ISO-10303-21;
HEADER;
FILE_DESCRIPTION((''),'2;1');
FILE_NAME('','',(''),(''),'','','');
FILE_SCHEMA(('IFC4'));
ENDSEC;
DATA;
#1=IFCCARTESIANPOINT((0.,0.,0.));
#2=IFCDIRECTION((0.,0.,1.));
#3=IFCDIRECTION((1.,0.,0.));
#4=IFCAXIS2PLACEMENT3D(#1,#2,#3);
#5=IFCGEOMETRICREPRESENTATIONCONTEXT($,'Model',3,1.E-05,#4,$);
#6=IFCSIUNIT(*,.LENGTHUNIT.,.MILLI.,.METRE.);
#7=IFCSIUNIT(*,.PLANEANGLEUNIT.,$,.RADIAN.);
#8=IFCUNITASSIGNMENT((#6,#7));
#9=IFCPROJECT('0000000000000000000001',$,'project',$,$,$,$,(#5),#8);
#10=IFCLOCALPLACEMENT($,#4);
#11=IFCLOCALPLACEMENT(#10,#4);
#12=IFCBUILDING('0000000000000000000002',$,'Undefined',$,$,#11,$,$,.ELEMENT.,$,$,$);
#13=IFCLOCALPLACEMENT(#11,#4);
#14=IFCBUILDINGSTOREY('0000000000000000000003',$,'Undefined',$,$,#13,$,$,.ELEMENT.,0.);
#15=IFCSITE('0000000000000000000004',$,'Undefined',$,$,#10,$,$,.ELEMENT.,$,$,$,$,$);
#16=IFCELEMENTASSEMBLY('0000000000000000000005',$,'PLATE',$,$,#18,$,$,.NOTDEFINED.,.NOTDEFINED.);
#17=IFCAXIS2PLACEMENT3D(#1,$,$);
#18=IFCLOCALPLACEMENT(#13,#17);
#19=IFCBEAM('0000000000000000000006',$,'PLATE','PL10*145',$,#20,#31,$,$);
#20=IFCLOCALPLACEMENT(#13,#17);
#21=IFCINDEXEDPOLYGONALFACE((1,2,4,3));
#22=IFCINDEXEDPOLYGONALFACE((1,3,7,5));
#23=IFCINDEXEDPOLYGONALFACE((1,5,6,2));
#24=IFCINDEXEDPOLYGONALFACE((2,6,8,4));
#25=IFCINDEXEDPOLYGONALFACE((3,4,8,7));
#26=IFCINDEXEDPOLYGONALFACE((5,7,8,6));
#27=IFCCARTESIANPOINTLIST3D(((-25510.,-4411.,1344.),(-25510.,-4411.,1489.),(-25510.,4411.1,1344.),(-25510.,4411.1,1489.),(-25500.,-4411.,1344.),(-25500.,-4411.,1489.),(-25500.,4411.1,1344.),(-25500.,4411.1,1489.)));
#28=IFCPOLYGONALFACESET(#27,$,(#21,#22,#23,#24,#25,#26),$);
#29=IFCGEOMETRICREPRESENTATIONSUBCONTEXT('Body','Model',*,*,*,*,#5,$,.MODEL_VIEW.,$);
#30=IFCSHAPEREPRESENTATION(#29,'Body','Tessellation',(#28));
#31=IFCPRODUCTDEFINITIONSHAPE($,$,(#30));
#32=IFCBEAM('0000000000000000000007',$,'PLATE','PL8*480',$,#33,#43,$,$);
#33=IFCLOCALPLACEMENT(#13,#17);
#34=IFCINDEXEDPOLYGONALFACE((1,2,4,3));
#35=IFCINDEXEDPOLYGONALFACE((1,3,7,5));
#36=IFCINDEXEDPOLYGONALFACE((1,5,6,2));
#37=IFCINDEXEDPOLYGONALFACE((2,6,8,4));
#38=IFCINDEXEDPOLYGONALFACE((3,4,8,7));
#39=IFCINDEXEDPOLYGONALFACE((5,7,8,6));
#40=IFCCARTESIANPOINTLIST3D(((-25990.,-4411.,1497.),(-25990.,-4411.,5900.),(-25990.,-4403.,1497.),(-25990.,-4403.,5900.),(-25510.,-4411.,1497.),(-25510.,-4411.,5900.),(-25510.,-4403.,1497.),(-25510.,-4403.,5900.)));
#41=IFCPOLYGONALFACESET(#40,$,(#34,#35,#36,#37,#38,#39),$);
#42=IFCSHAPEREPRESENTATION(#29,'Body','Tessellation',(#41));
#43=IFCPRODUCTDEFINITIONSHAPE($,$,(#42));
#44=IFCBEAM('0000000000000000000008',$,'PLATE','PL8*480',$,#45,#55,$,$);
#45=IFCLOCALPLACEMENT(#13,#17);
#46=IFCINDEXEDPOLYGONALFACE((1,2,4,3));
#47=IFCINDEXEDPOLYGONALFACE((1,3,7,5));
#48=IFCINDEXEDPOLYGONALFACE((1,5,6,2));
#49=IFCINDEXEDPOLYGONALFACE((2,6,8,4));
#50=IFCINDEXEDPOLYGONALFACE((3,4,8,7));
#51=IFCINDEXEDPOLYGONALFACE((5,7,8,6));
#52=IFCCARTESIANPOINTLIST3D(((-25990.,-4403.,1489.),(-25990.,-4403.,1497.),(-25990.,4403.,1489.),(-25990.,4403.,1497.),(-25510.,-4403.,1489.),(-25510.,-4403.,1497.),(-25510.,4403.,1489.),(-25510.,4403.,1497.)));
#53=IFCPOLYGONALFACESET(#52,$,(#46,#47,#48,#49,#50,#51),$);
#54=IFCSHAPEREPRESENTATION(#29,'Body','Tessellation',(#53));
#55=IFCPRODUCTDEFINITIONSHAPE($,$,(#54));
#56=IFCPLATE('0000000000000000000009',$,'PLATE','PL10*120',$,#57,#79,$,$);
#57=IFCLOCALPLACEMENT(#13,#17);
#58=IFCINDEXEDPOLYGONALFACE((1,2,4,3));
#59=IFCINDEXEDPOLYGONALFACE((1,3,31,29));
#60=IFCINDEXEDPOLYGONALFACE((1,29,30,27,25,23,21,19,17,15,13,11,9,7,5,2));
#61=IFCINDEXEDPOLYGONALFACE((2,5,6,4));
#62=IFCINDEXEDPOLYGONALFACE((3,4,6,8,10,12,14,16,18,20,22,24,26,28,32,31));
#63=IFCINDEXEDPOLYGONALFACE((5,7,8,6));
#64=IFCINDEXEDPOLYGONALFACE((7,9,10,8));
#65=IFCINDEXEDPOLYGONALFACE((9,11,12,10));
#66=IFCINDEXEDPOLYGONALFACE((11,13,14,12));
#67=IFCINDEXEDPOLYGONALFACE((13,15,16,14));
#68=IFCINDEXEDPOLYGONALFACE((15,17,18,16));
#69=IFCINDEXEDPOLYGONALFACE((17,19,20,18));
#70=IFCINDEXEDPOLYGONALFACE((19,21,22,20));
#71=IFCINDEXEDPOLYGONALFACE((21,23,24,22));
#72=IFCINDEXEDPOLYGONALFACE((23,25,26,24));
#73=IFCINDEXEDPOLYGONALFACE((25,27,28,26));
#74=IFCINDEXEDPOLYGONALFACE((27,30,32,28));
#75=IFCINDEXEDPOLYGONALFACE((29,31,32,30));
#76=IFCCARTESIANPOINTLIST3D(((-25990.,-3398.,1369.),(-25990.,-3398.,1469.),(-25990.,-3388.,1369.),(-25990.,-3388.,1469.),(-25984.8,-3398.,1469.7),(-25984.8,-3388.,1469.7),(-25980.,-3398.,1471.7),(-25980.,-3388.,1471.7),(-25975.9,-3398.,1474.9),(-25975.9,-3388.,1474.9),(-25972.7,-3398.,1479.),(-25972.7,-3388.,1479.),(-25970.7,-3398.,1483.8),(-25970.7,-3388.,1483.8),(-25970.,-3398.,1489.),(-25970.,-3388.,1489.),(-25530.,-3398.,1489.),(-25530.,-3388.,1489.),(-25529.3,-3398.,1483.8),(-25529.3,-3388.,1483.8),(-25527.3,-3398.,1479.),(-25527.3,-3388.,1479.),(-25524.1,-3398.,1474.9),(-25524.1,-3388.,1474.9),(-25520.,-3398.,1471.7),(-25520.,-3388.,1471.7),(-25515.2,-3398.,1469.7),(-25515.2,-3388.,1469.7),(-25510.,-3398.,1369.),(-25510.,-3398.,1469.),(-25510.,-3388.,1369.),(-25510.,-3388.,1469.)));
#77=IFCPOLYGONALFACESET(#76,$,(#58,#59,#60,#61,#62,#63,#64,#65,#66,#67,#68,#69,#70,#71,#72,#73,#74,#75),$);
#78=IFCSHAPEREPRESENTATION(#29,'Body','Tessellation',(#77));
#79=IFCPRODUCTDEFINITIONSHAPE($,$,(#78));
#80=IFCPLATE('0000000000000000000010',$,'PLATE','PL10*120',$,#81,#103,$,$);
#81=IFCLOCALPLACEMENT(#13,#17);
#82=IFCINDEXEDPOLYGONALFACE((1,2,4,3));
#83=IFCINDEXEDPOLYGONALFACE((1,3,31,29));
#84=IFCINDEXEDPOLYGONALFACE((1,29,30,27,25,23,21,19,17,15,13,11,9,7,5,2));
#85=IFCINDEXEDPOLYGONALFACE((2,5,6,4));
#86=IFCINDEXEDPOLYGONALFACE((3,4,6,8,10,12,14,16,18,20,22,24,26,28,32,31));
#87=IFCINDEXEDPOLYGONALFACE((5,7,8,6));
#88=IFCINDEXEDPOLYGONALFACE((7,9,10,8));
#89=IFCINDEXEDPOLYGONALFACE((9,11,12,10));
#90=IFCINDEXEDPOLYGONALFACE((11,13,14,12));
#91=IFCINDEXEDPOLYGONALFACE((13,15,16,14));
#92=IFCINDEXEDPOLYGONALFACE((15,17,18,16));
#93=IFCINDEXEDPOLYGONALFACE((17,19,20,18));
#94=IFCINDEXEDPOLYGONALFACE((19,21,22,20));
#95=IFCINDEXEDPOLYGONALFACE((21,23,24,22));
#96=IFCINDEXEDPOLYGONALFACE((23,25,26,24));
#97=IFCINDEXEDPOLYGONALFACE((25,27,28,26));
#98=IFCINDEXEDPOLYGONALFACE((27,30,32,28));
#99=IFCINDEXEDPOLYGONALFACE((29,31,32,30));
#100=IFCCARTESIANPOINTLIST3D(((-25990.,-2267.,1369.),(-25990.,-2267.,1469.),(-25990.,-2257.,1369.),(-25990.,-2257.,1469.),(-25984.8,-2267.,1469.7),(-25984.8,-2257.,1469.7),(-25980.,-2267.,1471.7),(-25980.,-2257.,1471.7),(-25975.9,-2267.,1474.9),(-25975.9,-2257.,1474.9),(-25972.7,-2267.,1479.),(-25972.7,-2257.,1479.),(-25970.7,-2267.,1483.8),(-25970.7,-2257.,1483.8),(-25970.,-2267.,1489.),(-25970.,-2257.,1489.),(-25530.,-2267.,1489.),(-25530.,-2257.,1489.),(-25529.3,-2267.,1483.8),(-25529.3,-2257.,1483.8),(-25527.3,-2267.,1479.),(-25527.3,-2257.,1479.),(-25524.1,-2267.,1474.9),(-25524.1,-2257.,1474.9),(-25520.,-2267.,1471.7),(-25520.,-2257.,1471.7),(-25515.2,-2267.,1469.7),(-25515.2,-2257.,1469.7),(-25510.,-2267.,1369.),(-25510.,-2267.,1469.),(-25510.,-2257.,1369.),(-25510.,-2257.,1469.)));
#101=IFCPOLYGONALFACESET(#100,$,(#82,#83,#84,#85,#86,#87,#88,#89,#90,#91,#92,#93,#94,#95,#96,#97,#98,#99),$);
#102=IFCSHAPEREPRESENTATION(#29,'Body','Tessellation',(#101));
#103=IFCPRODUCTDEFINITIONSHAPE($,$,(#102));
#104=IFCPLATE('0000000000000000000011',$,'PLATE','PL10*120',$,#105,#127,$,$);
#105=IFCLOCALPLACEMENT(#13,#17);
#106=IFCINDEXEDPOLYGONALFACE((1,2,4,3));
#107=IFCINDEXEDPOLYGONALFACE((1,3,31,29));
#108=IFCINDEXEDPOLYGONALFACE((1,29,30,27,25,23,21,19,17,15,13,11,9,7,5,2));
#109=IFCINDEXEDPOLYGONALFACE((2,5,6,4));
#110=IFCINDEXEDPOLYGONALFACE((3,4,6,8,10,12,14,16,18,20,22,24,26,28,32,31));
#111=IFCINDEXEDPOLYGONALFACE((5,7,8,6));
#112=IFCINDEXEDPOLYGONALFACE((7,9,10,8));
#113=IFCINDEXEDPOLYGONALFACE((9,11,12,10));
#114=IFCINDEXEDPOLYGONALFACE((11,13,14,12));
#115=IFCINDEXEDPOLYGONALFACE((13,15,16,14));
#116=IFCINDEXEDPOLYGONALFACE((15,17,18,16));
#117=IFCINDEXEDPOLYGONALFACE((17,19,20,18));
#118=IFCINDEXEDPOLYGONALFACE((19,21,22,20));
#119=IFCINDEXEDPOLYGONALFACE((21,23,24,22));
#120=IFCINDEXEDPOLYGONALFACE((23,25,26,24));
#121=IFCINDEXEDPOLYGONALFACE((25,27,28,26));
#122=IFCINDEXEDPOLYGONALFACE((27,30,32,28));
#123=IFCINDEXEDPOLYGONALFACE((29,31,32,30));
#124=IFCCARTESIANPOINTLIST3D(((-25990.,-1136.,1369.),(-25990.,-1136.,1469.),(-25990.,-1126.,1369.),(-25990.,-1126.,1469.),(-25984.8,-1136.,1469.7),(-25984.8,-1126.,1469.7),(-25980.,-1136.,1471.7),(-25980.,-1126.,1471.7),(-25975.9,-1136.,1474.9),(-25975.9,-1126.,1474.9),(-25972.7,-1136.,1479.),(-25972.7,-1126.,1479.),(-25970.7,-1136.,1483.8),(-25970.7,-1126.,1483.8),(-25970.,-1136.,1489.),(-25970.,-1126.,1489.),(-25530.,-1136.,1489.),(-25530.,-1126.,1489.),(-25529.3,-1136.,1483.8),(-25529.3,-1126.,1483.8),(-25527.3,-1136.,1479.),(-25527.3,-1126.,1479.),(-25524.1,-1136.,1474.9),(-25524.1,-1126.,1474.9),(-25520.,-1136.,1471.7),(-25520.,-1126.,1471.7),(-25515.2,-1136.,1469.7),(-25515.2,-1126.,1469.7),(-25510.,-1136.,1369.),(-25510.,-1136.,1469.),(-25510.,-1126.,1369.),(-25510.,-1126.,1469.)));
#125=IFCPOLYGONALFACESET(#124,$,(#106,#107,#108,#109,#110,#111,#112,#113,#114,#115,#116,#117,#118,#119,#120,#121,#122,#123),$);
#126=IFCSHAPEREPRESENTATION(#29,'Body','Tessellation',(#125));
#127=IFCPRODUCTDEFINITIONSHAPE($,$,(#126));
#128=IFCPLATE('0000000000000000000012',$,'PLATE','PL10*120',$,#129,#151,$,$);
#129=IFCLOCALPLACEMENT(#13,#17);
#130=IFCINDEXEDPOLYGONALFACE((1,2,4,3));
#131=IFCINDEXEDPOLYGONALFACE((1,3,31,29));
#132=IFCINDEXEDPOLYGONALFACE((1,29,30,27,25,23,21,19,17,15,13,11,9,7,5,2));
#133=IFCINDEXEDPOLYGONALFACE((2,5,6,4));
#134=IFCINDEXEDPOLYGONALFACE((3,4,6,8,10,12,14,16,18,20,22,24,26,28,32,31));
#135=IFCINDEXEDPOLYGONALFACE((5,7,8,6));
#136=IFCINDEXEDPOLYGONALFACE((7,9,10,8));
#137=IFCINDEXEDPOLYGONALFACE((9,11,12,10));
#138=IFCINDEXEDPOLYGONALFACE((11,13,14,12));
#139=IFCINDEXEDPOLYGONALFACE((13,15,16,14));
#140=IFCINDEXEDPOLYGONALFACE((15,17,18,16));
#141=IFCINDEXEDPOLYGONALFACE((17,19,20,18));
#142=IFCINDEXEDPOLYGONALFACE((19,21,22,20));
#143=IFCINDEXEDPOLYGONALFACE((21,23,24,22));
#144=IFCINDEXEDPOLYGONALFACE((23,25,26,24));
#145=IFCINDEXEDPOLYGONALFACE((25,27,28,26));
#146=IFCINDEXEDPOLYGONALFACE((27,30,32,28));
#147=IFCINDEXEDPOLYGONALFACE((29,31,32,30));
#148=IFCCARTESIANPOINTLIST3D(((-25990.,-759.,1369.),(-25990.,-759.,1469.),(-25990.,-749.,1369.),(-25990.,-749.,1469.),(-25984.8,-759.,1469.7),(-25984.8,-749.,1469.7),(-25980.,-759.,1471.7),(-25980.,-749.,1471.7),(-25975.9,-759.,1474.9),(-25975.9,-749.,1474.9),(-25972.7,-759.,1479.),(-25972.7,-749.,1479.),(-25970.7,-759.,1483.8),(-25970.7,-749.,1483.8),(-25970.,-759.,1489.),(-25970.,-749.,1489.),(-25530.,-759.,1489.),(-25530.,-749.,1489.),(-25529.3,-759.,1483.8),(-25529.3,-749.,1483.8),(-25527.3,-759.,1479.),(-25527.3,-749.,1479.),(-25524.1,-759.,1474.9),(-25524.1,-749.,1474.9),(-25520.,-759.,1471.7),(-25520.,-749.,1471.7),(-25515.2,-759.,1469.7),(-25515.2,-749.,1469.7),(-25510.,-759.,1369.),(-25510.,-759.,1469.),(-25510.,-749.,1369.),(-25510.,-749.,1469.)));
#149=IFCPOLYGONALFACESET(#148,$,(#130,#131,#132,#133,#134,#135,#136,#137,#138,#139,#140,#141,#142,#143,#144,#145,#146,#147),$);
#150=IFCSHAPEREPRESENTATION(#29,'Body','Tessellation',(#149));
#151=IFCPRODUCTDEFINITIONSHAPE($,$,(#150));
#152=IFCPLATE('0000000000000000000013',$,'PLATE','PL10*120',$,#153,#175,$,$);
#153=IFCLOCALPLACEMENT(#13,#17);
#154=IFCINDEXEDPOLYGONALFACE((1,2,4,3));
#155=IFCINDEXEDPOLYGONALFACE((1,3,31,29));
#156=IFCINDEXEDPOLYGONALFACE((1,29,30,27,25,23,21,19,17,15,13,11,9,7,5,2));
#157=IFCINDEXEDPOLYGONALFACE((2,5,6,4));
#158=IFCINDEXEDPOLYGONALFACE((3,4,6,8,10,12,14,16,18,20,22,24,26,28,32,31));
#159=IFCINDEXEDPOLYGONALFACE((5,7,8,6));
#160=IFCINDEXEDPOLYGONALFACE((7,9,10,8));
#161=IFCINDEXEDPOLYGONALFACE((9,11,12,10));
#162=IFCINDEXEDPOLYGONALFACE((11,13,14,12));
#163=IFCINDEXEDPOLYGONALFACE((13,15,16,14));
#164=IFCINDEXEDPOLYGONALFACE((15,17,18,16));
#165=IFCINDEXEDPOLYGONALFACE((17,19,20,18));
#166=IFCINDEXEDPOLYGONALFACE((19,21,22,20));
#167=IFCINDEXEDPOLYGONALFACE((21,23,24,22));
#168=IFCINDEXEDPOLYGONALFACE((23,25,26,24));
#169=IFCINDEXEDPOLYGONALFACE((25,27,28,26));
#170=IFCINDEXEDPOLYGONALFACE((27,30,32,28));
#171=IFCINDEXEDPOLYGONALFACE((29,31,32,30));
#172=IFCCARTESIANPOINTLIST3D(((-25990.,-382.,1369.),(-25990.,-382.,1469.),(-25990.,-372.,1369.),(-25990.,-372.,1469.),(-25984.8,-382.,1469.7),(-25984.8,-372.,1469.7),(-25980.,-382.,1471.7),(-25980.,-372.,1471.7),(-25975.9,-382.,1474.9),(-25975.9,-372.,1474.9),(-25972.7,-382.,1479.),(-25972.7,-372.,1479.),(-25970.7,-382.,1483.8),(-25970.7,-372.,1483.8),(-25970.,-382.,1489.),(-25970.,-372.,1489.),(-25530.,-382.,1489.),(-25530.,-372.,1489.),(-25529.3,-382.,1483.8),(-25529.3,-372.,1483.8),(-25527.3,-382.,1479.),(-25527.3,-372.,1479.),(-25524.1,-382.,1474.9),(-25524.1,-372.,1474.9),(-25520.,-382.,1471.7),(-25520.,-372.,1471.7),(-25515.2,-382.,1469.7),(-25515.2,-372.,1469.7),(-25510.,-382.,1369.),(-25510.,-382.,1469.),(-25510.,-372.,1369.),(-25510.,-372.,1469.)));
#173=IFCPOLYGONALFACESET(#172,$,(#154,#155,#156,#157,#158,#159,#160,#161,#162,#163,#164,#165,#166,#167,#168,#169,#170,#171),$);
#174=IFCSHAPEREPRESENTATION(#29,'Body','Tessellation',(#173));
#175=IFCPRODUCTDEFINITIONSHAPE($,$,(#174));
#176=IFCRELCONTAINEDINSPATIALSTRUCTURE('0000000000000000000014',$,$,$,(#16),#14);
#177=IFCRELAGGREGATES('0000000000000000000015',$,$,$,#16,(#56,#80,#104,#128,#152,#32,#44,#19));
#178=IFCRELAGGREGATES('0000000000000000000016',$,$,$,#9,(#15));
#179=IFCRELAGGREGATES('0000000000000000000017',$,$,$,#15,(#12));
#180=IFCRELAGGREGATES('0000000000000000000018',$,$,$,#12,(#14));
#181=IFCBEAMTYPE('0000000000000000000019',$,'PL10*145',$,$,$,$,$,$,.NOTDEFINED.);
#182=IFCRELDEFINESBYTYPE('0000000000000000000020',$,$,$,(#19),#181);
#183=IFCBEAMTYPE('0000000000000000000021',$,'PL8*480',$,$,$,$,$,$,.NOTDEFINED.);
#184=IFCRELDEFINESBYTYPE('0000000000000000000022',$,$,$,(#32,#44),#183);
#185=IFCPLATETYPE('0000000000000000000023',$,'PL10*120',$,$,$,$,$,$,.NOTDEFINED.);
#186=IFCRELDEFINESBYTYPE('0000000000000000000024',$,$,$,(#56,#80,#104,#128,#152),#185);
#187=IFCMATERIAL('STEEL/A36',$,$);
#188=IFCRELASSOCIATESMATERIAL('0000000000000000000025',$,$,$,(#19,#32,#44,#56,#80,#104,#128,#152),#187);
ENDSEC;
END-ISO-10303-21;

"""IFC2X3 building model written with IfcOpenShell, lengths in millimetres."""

from ifc_helpers import new_model, si_unit, frame, frame_2d, origin_with_axes, origin_2d_with_axis, place, context, subcontext, project, spatial, polyline, circle_curve, parameter, trimmed, segment, composite_curve, rectangle, outline, extrude, material, type_object, element, aggregate, save


model = new_model("IFC2X3")

# Units and contexts
model_context = context("Model", 3, precision=1e-05, world=origin_with_axes())
body_context = subcontext(model_context, "Body", "Model", "MODEL_VIEW")
ifc_project = project(units=[si_unit("LENGTHUNIT", "METRE", prefix="MILLI"), si_unit("PLANEANGLEUNIT", "RADIAN")], contexts=[model_context])

# Site, building, storey
site_placement = place(None, origin_with_axes())
site = spatial("IfcSite", under=ifc_project, at=site_placement, Name="Undefined", CompositionType="ELEMENT")
building_placement = place(site_placement, origin_with_axes())
building = spatial("IfcBuilding", under=site, at=building_placement, Name="Undefined", CompositionType="ELEMENT")
storey_placement = place(building_placement, origin_with_axes())
storey = spatial("IfcBuildingStorey", under=building, at=storey_placement, Name="Undefined", CompositionType="ELEMENT", Elevation=0.0)

# Element assembly
assembly_1_placement = place(storey_placement, origin_with_axes())
assembly_1 = element("IfcElementAssembly", 1, at=assembly_1_placement, inside=storey, Name="PLATE", AssemblyPlace="NOTDEFINED", PredefinedType="NOTDEFINED")
ifc_material_1 = material(Name="STEEL/A36")

# Beams
beam_type_1 = type_object("IfcBeamType", Name="PL10*145", PredefinedType="NOTDEFINED")
beam_1_placement = place(assembly_1_placement, frame((-25505.0, -4411.0, 1416.5), z_axis=(0.0, 0.0, -1.0), x_axis=(0.0, 1.0, 0.0)))
beam_1 = element("IfcBeam", 2, at=beam_1_placement, type_object=beam_type_1, material=ifc_material_1, Name="PLATE", Description="PL10*145", context=body_context, shape_type="SweptSolid", body=[
    extrude(rectangle(XDim=10.0, YDim=145.0, at=origin_2d_with_axis()), frame((8822.1, 0.0, 0.0), z_axis=(-1.0, 0.0, 0.0), x_axis=(0.0, -1.0, 0.0)), (0.0, 0.0, 1.0), 8822.1),
])
beam_type_2 = type_object("IfcBeamType", Name="PL8*480", PredefinedType="NOTDEFINED")
beam_2_placement = place(assembly_1_placement, frame((-25750.0, -4407.0, 1497.0), z_axis=(1.0, 0.0, 0.0), x_axis=(0.0, 0.0, 1.0)))
beam_2 = element("IfcBeam", 3, at=beam_2_placement, type_object=beam_type_2, material=ifc_material_1, Name="PLATE", Description="PL8*480", context=body_context, shape_type="SweptSolid", body=[
    extrude(rectangle(XDim=8.0, YDim=480.0, at=origin_2d_with_axis()), frame((4403.0, 0.0, 0.0), z_axis=(-1.0, 0.0, 0.0), x_axis=(0.0, -1.0, 0.0)), (0.0, 0.0, 1.0), 4403.0),
])
beam_3_placement = place(assembly_1_placement, frame((-25750.0, -4403.0, 1493.0), z_axis=(1.0, 0.0, 0.0), x_axis=(0.0, 1.0, 0.0)))
beam_3 = element("IfcBeam", 4, at=beam_3_placement, type_object=beam_type_2, material=ifc_material_1, Name="PLATE", Description="PL8*480", context=body_context, shape_type="SweptSolid", body=[
    extrude(rectangle(XDim=8.0, YDim=480.0, at=origin_2d_with_axis()), frame((8806.0, 0.0, 0.0), z_axis=(-1.0, 0.0, 0.0), x_axis=(0.0, -1.0, 0.0)), (0.0, 0.0, 1.0), 8806.0),
])

# Plates
plate_type_1 = type_object("IfcPlateType", Name="PL10*120", PredefinedType="NOTDEFINED")
plate_1_placement = place(assembly_1_placement, frame((-25510.0, -3393.0, 1369.0), z_axis=(0.0, 1.0, 0.0), x_axis=(-1.0, 0.0, 0.0)))
plate_1 = element("IfcPlate", 5, at=plate_1_placement, type_object=plate_type_1, material=ifc_material_1, Name="PLATE", Description="PL10*120", context=body_context, shape_type="SweptSolid", body=[
    extrude(outline(composite_curve([segment(polyline([(0.0, 0.0), (480.0, 0.0), (480.0, 100.0)]), True, "CONTINUOUS"), segment(trimmed(circle_curve(frame_2d((480.0, 120.0), x_axis=(-0.000015, -1.0)), 20.0), [parameter(0.0)], [parameter(4.712402)], False, "PARAMETER"), True, "CONTINUOUS"), segment(polyline([(460.0, 120.0), (20.0, 120.0)]), True, "CONTINUOUS"), segment(trimmed(circle_curve(frame_2d((0.0, 120.0), x_axis=(1.0, -0.000002)), 20.0), [parameter(0.0)], [parameter(4.712393)], False, "PARAMETER"), True, "CONTINUOUS"), segment(polyline([(0.0, 100.0), (0.0, 0.0)]), True, "CONTINUOUS")], self_intersect=True)), frame((0.0, 0.0, -5.0), z_axis=(0.0, 0.0, 1.0), x_axis=(1.0, 0.0, 0.0)), (0.0, 0.0, 1.0), 10.0),
])
plate_2_placement = place(assembly_1_placement, frame((-25510.0, -2262.0, 1369.0), z_axis=(0.0, 1.0, 0.0), x_axis=(-1.0, 0.0, 0.0)))
plate_2 = element("IfcPlate", 6, at=plate_2_placement, type_object=plate_type_1, material=ifc_material_1, Name="PLATE", Description="PL10*120", context=body_context, shape_type="SweptSolid", body=[
    extrude(outline(composite_curve([segment(polyline([(0.0, 0.0), (480.0, 0.0), (480.0, 100.0)]), True, "CONTINUOUS"), segment(trimmed(circle_curve(frame_2d((480.0, 120.0), x_axis=(-0.000015, -1.0)), 20.0), [parameter(0.0)], [parameter(4.712402)], False, "PARAMETER"), True, "CONTINUOUS"), segment(polyline([(460.0, 120.0), (20.0, 120.0)]), True, "CONTINUOUS"), segment(trimmed(circle_curve(frame_2d((0.0, 120.0), x_axis=(1.0, -0.000002)), 20.0), [parameter(0.0)], [parameter(4.712393)], False, "PARAMETER"), True, "CONTINUOUS"), segment(polyline([(0.0, 100.0), (0.0, 0.0)]), True, "CONTINUOUS")], self_intersect=True)), frame((0.0, 0.0, -5.0), z_axis=(0.0, 0.0, 1.0), x_axis=(1.0, 0.0, 0.0)), (0.0, 0.0, 1.0), 10.0),
])
plate_3_placement = place(assembly_1_placement, frame((-25510.0, -1131.0, 1369.0), z_axis=(0.0, 1.0, 0.0), x_axis=(-1.0, 0.0, 0.0)))
plate_3 = element("IfcPlate", 7, at=plate_3_placement, type_object=plate_type_1, material=ifc_material_1, Name="PLATE", Description="PL10*120", context=body_context, shape_type="SweptSolid", body=[
    extrude(outline(composite_curve([segment(polyline([(0.0, 0.0), (480.0, 0.0), (480.0, 100.0)]), True, "CONTINUOUS"), segment(trimmed(circle_curve(frame_2d((480.0, 120.0), x_axis=(-0.000015, -1.0)), 20.0), [parameter(0.0)], [parameter(4.712402)], False, "PARAMETER"), True, "CONTINUOUS"), segment(polyline([(460.0, 120.0), (20.0, 120.0)]), True, "CONTINUOUS"), segment(trimmed(circle_curve(frame_2d((0.0, 120.0), x_axis=(1.0, -0.000002)), 20.0), [parameter(0.0)], [parameter(4.712393)], False, "PARAMETER"), True, "CONTINUOUS"), segment(polyline([(0.0, 100.0), (0.0, 0.0)]), True, "CONTINUOUS")], self_intersect=True)), frame((0.0, 0.0, -5.0), z_axis=(0.0, 0.0, 1.0), x_axis=(1.0, 0.0, 0.0)), (0.0, 0.0, 1.0), 10.0),
])
plate_4_placement = place(assembly_1_placement, frame((-25510.0, -754.0, 1369.0), z_axis=(0.0, 1.0, 0.0), x_axis=(-1.0, 0.0, 0.0)))
plate_4 = element("IfcPlate", 8, at=plate_4_placement, type_object=plate_type_1, material=ifc_material_1, Name="PLATE", Description="PL10*120", context=body_context, shape_type="SweptSolid", body=[
    extrude(outline(composite_curve([segment(polyline([(0.0, 0.0), (480.0, 0.0), (480.0, 100.0)]), True, "CONTINUOUS"), segment(trimmed(circle_curve(frame_2d((480.0, 120.0), x_axis=(-0.000015, -1.0)), 20.0), [parameter(0.0)], [parameter(4.712402)], False, "PARAMETER"), True, "CONTINUOUS"), segment(polyline([(460.0, 120.0), (20.0, 120.0)]), True, "CONTINUOUS"), segment(trimmed(circle_curve(frame_2d((0.0, 120.0), x_axis=(1.0, -0.000002)), 20.0), [parameter(0.0)], [parameter(4.712393)], False, "PARAMETER"), True, "CONTINUOUS"), segment(polyline([(0.0, 100.0), (0.0, 0.0)]), True, "CONTINUOUS")], self_intersect=True)), frame((0.0, 0.0, -5.0), z_axis=(0.0, 0.0, 1.0), x_axis=(1.0, 0.0, 0.0)), (0.0, 0.0, 1.0), 10.0),
])
plate_5_placement = place(assembly_1_placement, frame((-25510.0, -377.0, 1369.0), z_axis=(0.0, 1.0, 0.0), x_axis=(-1.0, 0.0, 0.0)))
plate_5 = element("IfcPlate", 9, at=plate_5_placement, type_object=plate_type_1, material=ifc_material_1, Name="PLATE", Description="PL10*120", context=body_context, shape_type="SweptSolid", body=[
    extrude(outline(composite_curve([segment(polyline([(0.0, 0.0), (480.0, 0.0), (480.0, 100.0)]), True, "CONTINUOUS"), segment(trimmed(circle_curve(frame_2d((480.0, 120.0), x_axis=(-0.000015, -1.0)), 20.0), [parameter(0.0)], [parameter(4.712402)], False, "PARAMETER"), True, "CONTINUOUS"), segment(polyline([(460.0, 120.0), (20.0, 120.0)]), True, "CONTINUOUS"), segment(trimmed(circle_curve(frame_2d((0.0, 120.0), x_axis=(1.0, -0.000002)), 20.0), [parameter(0.0)], [parameter(4.712393)], False, "PARAMETER"), True, "CONTINUOUS"), segment(polyline([(0.0, 100.0), (0.0, 0.0)]), True, "CONTINUOUS")], self_intersect=True)), frame((0.0, 0.0, -5.0), z_axis=(0.0, 0.0, 1.0), x_axis=(1.0, 0.0, 0.0)), (0.0, 0.0, 1.0), 10.0),
])

aggregate(assembly_1, [plate_1, plate_2, plate_3, plate_4, plate_5, beam_2, beam_3, beam_1])

save(model, "model.ifc")
